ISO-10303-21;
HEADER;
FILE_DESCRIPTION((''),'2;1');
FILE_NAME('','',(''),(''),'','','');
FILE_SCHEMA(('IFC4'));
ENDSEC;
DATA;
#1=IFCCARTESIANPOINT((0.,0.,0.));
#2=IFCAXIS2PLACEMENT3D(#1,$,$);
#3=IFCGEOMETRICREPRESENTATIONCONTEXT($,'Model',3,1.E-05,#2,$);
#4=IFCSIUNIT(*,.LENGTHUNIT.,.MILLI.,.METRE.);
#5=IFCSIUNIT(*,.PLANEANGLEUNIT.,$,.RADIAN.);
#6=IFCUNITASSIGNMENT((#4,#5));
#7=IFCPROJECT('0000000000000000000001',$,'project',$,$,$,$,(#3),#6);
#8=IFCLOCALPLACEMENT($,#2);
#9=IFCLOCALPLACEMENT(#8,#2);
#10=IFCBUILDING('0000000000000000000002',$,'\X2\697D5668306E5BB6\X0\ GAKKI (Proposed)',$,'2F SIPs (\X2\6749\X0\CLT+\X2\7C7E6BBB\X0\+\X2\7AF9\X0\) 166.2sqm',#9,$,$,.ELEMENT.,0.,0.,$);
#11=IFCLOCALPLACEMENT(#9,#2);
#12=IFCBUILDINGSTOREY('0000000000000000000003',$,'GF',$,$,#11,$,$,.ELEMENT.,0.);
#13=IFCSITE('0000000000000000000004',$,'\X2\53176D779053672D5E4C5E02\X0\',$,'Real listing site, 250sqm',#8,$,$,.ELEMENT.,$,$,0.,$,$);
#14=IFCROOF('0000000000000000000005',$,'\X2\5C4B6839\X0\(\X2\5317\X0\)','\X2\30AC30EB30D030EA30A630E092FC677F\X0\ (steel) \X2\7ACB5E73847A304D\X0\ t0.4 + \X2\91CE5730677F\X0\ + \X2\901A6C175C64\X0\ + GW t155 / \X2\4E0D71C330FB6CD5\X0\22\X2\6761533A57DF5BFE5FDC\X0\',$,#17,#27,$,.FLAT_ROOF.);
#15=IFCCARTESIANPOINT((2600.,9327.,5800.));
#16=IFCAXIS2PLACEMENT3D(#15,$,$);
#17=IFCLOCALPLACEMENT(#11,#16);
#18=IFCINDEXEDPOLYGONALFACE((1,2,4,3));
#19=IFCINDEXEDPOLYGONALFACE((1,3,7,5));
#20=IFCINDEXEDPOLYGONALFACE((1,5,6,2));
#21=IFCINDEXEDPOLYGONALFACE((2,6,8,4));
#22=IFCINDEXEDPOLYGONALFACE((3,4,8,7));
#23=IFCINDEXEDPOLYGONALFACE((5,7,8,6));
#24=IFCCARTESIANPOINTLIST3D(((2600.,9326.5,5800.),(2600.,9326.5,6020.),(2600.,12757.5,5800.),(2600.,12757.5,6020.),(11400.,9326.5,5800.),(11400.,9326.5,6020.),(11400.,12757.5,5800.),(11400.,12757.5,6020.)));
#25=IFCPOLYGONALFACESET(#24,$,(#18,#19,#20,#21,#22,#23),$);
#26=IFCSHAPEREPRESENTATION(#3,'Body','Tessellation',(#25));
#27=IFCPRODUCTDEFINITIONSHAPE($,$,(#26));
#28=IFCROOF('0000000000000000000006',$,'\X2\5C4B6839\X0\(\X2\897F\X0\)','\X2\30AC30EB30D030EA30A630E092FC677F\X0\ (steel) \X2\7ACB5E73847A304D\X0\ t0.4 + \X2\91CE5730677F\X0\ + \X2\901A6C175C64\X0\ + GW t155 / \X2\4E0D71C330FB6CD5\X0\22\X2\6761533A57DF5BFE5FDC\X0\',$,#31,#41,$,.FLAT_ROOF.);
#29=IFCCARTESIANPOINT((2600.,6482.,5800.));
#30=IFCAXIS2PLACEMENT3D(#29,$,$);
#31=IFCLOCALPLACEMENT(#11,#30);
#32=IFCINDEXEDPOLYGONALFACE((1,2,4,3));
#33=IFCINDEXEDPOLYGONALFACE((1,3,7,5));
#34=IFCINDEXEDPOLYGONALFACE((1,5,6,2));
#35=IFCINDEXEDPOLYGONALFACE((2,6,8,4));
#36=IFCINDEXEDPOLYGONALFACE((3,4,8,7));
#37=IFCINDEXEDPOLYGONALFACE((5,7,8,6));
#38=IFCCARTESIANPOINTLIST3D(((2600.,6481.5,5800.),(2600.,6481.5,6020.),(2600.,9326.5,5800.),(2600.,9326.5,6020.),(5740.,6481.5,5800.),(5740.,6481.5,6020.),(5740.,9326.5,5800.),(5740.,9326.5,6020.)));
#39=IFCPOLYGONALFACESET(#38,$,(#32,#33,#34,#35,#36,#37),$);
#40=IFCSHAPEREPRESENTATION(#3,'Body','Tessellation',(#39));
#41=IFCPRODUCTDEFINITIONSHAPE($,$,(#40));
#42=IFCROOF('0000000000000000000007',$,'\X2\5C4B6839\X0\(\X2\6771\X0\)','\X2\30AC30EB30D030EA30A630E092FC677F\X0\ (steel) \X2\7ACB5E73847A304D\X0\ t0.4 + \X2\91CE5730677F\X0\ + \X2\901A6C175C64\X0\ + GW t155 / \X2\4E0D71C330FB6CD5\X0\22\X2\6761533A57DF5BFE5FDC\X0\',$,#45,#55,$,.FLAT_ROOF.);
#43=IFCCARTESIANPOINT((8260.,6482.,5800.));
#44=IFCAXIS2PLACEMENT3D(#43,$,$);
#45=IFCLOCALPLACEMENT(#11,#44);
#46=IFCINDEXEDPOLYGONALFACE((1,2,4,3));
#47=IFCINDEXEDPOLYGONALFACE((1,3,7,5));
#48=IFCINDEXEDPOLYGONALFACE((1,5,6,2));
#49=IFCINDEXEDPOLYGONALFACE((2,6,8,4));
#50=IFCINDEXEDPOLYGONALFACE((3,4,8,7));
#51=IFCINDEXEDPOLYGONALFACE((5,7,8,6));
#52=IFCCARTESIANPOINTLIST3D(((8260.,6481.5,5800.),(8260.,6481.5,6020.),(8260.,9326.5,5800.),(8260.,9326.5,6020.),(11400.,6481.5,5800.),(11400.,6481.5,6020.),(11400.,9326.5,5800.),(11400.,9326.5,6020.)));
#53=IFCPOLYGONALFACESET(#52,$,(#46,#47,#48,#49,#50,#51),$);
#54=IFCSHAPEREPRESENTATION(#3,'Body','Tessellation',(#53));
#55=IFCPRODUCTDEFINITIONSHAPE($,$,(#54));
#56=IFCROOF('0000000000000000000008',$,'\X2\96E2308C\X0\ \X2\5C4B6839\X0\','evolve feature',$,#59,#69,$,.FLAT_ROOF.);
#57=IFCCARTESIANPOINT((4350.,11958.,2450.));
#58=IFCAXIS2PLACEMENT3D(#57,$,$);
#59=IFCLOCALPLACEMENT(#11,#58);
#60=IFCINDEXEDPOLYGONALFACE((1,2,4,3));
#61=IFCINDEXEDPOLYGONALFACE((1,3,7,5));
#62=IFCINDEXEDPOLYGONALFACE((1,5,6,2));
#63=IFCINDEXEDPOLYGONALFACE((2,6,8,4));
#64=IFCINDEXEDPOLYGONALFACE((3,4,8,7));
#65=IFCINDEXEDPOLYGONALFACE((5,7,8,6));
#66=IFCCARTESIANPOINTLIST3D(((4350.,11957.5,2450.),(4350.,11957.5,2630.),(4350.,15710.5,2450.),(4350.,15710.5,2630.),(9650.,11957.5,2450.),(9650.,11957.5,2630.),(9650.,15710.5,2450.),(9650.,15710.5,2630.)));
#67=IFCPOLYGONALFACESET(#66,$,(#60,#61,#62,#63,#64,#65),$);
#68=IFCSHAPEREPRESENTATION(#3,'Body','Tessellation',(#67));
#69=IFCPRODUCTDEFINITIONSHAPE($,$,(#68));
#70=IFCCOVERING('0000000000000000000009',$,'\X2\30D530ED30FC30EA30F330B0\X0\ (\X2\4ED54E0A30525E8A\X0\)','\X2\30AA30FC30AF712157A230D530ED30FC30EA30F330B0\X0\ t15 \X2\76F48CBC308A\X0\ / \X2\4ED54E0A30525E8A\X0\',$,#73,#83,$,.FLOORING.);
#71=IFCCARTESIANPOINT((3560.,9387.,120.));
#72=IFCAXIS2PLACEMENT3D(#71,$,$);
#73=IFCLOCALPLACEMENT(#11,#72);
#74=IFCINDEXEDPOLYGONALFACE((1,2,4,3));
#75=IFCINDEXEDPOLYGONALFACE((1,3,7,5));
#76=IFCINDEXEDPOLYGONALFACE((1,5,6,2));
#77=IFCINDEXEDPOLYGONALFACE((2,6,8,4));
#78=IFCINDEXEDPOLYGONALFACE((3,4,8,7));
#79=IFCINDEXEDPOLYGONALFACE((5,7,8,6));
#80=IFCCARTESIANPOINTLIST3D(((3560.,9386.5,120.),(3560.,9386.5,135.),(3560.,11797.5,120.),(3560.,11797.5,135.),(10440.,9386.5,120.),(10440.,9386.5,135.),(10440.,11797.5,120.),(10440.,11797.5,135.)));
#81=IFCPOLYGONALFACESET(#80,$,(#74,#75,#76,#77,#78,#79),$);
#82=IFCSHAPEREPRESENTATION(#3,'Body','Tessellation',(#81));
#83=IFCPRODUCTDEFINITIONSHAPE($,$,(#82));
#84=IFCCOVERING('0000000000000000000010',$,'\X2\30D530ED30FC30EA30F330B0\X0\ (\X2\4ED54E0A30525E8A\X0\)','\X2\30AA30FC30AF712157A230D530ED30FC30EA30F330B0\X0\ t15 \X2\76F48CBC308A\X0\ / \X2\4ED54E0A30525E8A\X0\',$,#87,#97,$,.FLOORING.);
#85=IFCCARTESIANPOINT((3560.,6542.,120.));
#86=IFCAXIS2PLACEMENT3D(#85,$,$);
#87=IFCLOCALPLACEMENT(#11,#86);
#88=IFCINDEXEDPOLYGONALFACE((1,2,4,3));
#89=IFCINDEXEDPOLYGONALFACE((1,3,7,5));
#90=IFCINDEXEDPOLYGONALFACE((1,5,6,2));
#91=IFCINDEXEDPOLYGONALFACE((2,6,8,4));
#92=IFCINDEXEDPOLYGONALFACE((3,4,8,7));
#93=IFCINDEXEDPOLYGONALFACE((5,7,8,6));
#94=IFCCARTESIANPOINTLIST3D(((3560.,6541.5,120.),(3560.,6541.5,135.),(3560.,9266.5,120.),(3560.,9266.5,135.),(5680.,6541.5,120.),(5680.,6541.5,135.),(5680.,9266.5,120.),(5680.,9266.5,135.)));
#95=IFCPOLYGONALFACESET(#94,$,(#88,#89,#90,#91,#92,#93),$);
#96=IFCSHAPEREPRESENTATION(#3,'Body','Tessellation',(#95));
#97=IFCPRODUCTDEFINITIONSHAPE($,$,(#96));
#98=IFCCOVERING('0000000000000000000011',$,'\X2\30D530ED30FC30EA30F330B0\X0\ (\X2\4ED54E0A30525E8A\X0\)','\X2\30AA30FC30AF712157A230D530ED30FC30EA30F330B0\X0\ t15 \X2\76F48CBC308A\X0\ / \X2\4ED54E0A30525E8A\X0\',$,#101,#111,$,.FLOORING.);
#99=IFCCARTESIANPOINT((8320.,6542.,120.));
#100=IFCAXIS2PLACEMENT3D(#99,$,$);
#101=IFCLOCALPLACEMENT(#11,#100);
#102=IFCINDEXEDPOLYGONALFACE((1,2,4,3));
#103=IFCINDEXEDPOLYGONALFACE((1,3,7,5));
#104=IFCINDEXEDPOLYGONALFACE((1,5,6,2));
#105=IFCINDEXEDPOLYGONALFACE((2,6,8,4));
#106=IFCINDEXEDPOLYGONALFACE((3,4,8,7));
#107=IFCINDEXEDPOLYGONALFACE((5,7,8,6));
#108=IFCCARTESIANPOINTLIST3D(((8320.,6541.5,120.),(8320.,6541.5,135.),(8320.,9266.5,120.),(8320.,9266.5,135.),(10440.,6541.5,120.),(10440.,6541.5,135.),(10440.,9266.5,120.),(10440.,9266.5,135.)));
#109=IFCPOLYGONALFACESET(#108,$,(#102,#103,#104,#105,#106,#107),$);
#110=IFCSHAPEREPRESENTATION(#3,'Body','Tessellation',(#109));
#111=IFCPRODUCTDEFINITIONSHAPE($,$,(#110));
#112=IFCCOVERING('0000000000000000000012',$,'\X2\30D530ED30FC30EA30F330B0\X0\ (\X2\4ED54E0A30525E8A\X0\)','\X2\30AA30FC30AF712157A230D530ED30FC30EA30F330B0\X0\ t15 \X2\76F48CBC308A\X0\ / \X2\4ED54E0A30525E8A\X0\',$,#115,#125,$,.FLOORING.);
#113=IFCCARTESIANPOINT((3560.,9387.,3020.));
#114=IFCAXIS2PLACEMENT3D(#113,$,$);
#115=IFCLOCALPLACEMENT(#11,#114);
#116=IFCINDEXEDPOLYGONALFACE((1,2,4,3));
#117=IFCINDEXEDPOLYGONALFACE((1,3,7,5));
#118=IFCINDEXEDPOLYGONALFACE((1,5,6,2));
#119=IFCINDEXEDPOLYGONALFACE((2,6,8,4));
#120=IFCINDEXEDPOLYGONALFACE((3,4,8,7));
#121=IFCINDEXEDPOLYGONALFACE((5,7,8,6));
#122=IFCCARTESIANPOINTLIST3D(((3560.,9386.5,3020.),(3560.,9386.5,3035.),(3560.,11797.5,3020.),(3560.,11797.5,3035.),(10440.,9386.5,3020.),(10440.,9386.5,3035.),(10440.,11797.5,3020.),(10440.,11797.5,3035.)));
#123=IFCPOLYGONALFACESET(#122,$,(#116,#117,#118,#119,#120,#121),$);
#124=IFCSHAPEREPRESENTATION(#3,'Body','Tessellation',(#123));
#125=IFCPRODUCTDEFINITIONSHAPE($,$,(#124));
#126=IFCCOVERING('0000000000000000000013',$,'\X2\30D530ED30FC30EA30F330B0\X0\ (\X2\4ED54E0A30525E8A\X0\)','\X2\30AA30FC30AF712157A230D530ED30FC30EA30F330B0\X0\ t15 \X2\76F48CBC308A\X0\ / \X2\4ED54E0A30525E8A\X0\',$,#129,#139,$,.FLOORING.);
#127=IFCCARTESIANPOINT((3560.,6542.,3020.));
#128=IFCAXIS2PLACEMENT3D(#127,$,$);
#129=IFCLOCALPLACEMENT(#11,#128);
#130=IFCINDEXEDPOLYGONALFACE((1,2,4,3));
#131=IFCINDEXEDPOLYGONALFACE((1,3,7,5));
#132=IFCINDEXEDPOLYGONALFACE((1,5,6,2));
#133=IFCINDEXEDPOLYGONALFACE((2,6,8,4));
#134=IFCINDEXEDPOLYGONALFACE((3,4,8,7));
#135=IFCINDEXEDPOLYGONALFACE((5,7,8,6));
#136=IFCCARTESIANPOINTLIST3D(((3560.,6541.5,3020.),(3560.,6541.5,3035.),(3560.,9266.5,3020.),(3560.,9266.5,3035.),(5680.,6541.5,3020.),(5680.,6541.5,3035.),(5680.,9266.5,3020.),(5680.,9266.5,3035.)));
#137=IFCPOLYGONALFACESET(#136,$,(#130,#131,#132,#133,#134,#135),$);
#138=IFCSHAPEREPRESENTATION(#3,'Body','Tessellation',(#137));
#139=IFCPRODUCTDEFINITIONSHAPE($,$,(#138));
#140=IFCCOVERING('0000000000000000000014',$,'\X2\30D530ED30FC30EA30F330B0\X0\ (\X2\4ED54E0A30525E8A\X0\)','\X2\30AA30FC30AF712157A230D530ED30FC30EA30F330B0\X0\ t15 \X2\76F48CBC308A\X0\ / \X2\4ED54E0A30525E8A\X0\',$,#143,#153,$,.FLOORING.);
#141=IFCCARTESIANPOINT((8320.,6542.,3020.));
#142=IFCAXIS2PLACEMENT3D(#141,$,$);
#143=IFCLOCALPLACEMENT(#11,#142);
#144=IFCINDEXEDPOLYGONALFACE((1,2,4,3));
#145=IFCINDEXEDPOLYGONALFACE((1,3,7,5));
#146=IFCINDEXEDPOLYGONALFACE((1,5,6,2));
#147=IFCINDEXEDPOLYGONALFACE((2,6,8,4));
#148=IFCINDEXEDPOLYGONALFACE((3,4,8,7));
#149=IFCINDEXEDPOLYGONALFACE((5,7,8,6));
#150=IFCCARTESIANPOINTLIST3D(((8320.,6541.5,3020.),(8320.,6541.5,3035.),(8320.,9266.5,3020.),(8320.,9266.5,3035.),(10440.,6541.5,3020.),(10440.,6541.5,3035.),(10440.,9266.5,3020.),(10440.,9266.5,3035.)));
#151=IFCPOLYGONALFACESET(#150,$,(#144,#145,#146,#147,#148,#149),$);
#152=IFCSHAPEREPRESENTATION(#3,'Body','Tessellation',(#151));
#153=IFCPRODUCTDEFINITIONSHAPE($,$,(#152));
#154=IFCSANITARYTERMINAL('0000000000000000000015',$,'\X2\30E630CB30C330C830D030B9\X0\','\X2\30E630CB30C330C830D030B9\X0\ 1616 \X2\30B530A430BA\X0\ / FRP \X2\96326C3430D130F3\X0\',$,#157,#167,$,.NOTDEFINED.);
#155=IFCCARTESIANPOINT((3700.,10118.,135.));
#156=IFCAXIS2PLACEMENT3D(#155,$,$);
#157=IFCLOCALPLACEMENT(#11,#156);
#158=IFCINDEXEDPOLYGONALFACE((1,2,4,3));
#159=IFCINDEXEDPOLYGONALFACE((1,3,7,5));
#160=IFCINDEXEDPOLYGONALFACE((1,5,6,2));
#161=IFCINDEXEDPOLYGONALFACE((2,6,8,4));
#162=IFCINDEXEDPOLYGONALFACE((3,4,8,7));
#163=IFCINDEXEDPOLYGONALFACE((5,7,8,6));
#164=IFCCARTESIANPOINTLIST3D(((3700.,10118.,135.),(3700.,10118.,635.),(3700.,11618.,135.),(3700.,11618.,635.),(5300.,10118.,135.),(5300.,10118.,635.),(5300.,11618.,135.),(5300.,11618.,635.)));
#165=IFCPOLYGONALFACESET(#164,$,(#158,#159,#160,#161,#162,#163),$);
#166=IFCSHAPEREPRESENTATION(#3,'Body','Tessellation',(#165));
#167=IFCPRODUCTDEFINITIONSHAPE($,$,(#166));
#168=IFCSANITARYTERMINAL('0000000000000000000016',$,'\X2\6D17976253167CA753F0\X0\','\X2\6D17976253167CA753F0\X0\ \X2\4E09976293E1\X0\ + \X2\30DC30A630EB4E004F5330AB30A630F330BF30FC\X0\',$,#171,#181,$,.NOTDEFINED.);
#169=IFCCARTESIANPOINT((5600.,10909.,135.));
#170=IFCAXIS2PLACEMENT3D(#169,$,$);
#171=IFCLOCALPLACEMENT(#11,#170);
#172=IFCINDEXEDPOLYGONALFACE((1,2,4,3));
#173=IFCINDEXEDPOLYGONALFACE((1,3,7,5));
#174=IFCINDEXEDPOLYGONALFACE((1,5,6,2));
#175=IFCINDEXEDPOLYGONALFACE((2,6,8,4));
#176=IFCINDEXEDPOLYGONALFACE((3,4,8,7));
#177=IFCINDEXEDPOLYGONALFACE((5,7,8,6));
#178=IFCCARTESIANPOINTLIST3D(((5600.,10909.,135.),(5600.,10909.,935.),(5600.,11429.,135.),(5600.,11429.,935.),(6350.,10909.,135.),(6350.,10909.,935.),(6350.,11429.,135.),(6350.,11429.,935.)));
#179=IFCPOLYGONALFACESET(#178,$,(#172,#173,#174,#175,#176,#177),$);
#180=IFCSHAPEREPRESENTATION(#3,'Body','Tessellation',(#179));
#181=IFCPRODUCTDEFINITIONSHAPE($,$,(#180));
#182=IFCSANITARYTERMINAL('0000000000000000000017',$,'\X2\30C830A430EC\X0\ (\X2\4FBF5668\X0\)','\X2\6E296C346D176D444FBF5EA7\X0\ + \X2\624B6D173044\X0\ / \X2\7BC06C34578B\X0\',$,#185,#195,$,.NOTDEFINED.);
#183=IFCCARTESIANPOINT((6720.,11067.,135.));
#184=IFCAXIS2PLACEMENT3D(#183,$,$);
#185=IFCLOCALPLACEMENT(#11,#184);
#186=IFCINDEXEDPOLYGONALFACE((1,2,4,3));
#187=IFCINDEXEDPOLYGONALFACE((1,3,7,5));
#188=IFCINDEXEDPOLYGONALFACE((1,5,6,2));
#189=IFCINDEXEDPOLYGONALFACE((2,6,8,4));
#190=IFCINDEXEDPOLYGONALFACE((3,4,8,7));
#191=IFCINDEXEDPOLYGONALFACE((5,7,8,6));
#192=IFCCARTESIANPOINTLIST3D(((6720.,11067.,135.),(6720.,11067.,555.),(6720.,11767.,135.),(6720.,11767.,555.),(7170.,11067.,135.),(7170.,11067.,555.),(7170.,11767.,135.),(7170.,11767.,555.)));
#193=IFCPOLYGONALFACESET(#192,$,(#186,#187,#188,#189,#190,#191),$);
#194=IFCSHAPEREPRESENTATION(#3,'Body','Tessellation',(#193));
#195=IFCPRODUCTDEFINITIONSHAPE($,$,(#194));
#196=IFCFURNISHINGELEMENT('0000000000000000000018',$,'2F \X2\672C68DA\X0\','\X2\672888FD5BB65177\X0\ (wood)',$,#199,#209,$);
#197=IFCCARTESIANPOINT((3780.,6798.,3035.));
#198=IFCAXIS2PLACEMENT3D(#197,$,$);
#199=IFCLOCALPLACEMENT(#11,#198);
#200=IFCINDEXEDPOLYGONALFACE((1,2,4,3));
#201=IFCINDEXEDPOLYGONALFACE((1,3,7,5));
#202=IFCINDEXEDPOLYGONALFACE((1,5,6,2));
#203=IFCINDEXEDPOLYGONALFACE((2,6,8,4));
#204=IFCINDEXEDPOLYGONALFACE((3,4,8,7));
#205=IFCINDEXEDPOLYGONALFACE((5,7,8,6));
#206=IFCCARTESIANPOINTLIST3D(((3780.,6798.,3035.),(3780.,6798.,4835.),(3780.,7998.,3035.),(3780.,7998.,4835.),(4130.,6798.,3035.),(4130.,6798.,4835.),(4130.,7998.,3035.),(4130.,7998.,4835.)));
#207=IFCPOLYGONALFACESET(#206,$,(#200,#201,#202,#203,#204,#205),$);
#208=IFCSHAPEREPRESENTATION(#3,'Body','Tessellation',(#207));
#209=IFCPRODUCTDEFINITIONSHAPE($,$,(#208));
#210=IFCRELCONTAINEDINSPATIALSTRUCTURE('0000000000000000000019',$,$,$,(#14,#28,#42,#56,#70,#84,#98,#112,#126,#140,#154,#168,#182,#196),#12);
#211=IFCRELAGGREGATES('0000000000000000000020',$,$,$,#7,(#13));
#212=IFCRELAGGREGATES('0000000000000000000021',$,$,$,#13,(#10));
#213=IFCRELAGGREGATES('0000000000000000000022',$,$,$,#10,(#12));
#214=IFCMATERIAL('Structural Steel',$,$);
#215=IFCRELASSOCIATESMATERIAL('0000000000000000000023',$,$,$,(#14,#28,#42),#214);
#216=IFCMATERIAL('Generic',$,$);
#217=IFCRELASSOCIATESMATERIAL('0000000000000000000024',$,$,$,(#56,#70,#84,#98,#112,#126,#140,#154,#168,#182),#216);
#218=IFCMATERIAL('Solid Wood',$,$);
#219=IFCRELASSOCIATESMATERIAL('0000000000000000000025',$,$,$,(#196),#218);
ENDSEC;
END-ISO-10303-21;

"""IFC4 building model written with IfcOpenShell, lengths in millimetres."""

from ifc_helpers import new_model, si_unit, frame, frame_2d, origin, place, context, project, spatial, rectangle, extrude, material, element, save


model = new_model("IFC4")

# Units and contexts
model_context = context("Model", 3, precision=1e-05, world=origin())
ifc_project = project(units=[si_unit("LENGTHUNIT", "METRE", prefix="MILLI"), si_unit("PLANEANGLEUNIT", "RADIAN")], contexts=[model_context])

# Site, building, storey
site_placement = place(None, origin())
site = spatial("IfcSite", under=ifc_project, at=site_placement, Name="北海道札幌市", ObjectType="Real listing site, 250sqm", CompositionType="ELEMENT", RefElevation=0.0)
building_placement = place(site_placement, origin())
building = spatial("IfcBuilding", under=site, at=building_placement, Name="楽器の家 GAKKI (Proposed)", ObjectType="2F SIPs (杉CLT+籾殻+竹) 166.2sqm", CompositionType="ELEMENT", ElevationOfRefHeight=0.0, ElevationOfTerrain=0.0)
storey_placement = place(building_placement, origin())
storey = spatial("IfcBuildingStorey", under=building, at=storey_placement, Name="GF", CompositionType="ELEMENT", Elevation=0.0)

# Shared definitions
ifc_material_1 = material(Name="Solid Wood")
ifc_material_2 = material(Name="Generic")

# Roofs
ifc_material_3 = material(Name="Structural Steel")
for number, where, name in (
    (1, (2600.0, 9327.0, 5800.0), "屋根(北)"),
):
    element("IfcRoof", number, at=place(storey_placement, frame(where)), inside=storey, material=ifc_material_3, Name=name, Description="ガルバリウム鋼板 (steel) 立平葺き t0.4 + 野地板 + 通気層 + GW t155 / 不燃・法22条区域対応", PredefinedType="FLAT_ROOF", context=model_context, shape_type="SweptSolid", body=[
        extrude(rectangle(XDim=8800.0, YDim=3431.0, at=frame_2d((4400.0, 1715.0))), frame((2600.0, 9327.0, 5800.0)), (0.0, 0.0, 1.0), 220.0),
    ])
roof_1_placement = place(storey_placement, frame((2600.0, 6482.0, 5800.0)))
element("IfcRoof", 2, at=roof_1_placement, inside=storey, material=ifc_material_3, Name="屋根(西)", Description="ガルバリウム鋼板 (steel) 立平葺き t0.4 + 野地板 + 通気層 + GW t155 / 不燃・法22条区域対応", PredefinedType="FLAT_ROOF", context=model_context, shape_type="SweptSolid", body=[
    extrude(rectangle(XDim=3140.0, YDim=2845.0, at=frame_2d((1570.0, 1422.0))), frame((2600.0, 6482.0, 5800.0)), (0.0, 0.0, 1.0), 220.0),
])
roof_2_placement = place(storey_placement, frame((8260.0, 6482.0, 5800.0)))
element("IfcRoof", 3, at=roof_2_placement, inside=storey, material=ifc_material_3, Name="屋根(東)", Description="ガルバリウム鋼板 (steel) 立平葺き t0.4 + 野地板 + 通気層 + GW t155 / 不燃・法22条区域対応", PredefinedType="FLAT_ROOF", context=model_context, shape_type="SweptSolid", body=[
    extrude(rectangle(XDim=3140.0, YDim=2845.0, at=frame_2d((1570.0, 1422.0))), frame((8260.0, 6482.0, 5800.0)), (0.0, 0.0, 1.0), 220.0),
])
roof_3_placement = place(storey_placement, frame((4350.0, 11958.0, 2450.0)))
element("IfcRoof", 4, at=roof_3_placement, inside=storey, material=ifc_material_2, Name="離れ 屋根", Description="evolve feature", PredefinedType="FLAT_ROOF", context=model_context, shape_type="SweptSolid", body=[
    extrude(rectangle(XDim=5300.0, YDim=3753.0, at=frame_2d((2650.0, 1876.0))), frame((4350.0, 11958.0, 2450.0)), (0.0, 0.0, 1.0), 180.0),
])

# Coverings
covering_1_placement = place(storey_placement, frame((3560.0, 9387.0, 120.0)))
element("IfcCovering", 5, at=covering_1_placement, inside=storey, material=ifc_material_2, Name="フローリング (仕上げ床)", Description="オーク無垢フローリング t15 直貼り / 仕上げ床", PredefinedType="FLOORING", context=model_context, shape_type="SweptSolid", body=[
    extrude(rectangle(XDim=6880.0, YDim=2411.0, at=frame_2d((3440.0, 1205.0))), frame((3560.0, 9387.0, 120.0)), (0.0, 0.0, 1.0), 15.0),
])
covering_2_placement = place(storey_placement, frame((3560.0, 6542.0, 120.0)))
element("IfcCovering", 6, at=covering_2_placement, inside=storey, material=ifc_material_2, Name="フローリング (仕上げ床)", Description="オーク無垢フローリング t15 直貼り / 仕上げ床", PredefinedType="FLOORING", context=model_context, shape_type="SweptSolid", body=[
    extrude(rectangle(XDim=2120.0, YDim=2725.0, at=frame_2d((1060.0, 1362.0))), frame((3560.0, 6542.0, 120.0)), (0.0, 0.0, 1.0), 15.0),
])
covering_3_placement = place(storey_placement, frame((8320.0, 6542.0, 120.0)))
element("IfcCovering", 7, at=covering_3_placement, inside=storey, material=ifc_material_2, Name="フローリング (仕上げ床)", Description="オーク無垢フローリング t15 直貼り / 仕上げ床", PredefinedType="FLOORING", context=model_context, shape_type="SweptSolid", body=[
    extrude(rectangle(XDim=2120.0, YDim=2725.0, at=frame_2d((1060.0, 1362.0))), frame((8320.0, 6542.0, 120.0)), (0.0, 0.0, 1.0), 15.0),
])
covering_4_placement = place(storey_placement, frame((3560.0, 9387.0, 3020.0)))
element("IfcCovering", 8, at=covering_4_placement, inside=storey, material=ifc_material_2, Name="フローリング (仕上げ床)", Description="オーク無垢フローリング t15 直貼り / 仕上げ床", PredefinedType="FLOORING", context=model_context, shape_type="SweptSolid", body=[
    extrude(rectangle(XDim=6880.0, YDim=2411.0, at=frame_2d((3440.0, 1205.0))), frame((3560.0, 9387.0, 3020.0)), (0.0, 0.0, 1.0), 15.0),
])
covering_5_placement = place(storey_placement, frame((3560.0, 6542.0, 3020.0)))
element("IfcCovering", 9, at=covering_5_placement, inside=storey, material=ifc_material_2, Name="フローリング (仕上げ床)", Description="オーク無垢フローリング t15 直貼り / 仕上げ床", PredefinedType="FLOORING", context=model_context, shape_type="SweptSolid", body=[
    extrude(rectangle(XDim=2120.0, YDim=2725.0, at=frame_2d((1060.0, 1362.0))), frame((3560.0, 6542.0, 3020.0)), (0.0, 0.0, 1.0), 15.0),
])
covering_6_placement = place(storey_placement, frame((8320.0, 6542.0, 3020.0)))
element("IfcCovering", 10, at=covering_6_placement, inside=storey, material=ifc_material_2, Name="フローリング (仕上げ床)", Description="オーク無垢フローリング t15 直貼り / 仕上げ床", PredefinedType="FLOORING", context=model_context, shape_type="SweptSolid", body=[
    extrude(rectangle(XDim=2120.0, YDim=2725.0, at=frame_2d((1060.0, 1362.0))), frame((8320.0, 6542.0, 3020.0)), (0.0, 0.0, 1.0), 15.0),
])

# Sanitary terminals
sanitary_terminal_1_placement = place(storey_placement, frame((3700.0, 10118.0, 135.0)))
element("IfcSanitaryTerminal", 11, at=sanitary_terminal_1_placement, inside=storey, material=ifc_material_2, Name="ユニットバス", Description="ユニットバス 1616 サイズ / FRP 防水パン", PredefinedType="NOTDEFINED", context=model_context, shape_type="SweptSolid", body=[
    extrude(rectangle(XDim=1600.0, YDim=1500.0, at=frame_2d((800.0, 750.0))), frame((3700.0, 10118.0, 135.0)), (0.0, 0.0, 1.0), 500.0),
])
sanitary_terminal_2_placement = place(storey_placement, frame((5600.0, 10909.0, 135.0)))
element("IfcSanitaryTerminal", 12, at=sanitary_terminal_2_placement, inside=storey, material=ifc_material_2, Name="洗面化粧台", Description="洗面化粧台 三面鏡 + ボウル一体カウンター", PredefinedType="NOTDEFINED", context=model_context, shape_type="SweptSolid", body=[
    extrude(rectangle(XDim=750.0, YDim=520.0, at=frame_2d((375.0, 260.0))), frame((5600.0, 10909.0, 135.0)), (0.0, 0.0, 1.0), 800.0),
])
sanitary_terminal_3_placement = place(storey_placement, frame((6720.0, 11067.0, 135.0)))
element("IfcSanitaryTerminal", 13, at=sanitary_terminal_3_placement, inside=storey, material=ifc_material_2, Name="トイレ (便器)", Description="温水洗浄便座 + 手洗い / 節水型", PredefinedType="NOTDEFINED", context=model_context, shape_type="SweptSolid", body=[
    extrude(rectangle(XDim=450.0, YDim=700.0, at=frame_2d((225.0, 350.0))), frame((6720.0, 11067.0, 135.0)), (0.0, 0.0, 1.0), 420.0),
])

# Furnishing element
furnishing_placement = place(storey_placement, frame((3780.0, 6798.0, 3035.0)))
element("IfcFurnishingElement", 14, at=furnishing_placement, inside=storey, material=ifc_material_1, Name="2F 本棚", Description="木製家具 (wood)", context=model_context, shape_type="SweptSolid", body=[
    extrude(rectangle(XDim=350.0, YDim=1200.0, at=frame_2d((175.0, 600.0))), frame((3780.0, 6798.0, 3035.0)), (0.0, 0.0, 1.0), 1800.0),
])

save(model, "model.ifc")
